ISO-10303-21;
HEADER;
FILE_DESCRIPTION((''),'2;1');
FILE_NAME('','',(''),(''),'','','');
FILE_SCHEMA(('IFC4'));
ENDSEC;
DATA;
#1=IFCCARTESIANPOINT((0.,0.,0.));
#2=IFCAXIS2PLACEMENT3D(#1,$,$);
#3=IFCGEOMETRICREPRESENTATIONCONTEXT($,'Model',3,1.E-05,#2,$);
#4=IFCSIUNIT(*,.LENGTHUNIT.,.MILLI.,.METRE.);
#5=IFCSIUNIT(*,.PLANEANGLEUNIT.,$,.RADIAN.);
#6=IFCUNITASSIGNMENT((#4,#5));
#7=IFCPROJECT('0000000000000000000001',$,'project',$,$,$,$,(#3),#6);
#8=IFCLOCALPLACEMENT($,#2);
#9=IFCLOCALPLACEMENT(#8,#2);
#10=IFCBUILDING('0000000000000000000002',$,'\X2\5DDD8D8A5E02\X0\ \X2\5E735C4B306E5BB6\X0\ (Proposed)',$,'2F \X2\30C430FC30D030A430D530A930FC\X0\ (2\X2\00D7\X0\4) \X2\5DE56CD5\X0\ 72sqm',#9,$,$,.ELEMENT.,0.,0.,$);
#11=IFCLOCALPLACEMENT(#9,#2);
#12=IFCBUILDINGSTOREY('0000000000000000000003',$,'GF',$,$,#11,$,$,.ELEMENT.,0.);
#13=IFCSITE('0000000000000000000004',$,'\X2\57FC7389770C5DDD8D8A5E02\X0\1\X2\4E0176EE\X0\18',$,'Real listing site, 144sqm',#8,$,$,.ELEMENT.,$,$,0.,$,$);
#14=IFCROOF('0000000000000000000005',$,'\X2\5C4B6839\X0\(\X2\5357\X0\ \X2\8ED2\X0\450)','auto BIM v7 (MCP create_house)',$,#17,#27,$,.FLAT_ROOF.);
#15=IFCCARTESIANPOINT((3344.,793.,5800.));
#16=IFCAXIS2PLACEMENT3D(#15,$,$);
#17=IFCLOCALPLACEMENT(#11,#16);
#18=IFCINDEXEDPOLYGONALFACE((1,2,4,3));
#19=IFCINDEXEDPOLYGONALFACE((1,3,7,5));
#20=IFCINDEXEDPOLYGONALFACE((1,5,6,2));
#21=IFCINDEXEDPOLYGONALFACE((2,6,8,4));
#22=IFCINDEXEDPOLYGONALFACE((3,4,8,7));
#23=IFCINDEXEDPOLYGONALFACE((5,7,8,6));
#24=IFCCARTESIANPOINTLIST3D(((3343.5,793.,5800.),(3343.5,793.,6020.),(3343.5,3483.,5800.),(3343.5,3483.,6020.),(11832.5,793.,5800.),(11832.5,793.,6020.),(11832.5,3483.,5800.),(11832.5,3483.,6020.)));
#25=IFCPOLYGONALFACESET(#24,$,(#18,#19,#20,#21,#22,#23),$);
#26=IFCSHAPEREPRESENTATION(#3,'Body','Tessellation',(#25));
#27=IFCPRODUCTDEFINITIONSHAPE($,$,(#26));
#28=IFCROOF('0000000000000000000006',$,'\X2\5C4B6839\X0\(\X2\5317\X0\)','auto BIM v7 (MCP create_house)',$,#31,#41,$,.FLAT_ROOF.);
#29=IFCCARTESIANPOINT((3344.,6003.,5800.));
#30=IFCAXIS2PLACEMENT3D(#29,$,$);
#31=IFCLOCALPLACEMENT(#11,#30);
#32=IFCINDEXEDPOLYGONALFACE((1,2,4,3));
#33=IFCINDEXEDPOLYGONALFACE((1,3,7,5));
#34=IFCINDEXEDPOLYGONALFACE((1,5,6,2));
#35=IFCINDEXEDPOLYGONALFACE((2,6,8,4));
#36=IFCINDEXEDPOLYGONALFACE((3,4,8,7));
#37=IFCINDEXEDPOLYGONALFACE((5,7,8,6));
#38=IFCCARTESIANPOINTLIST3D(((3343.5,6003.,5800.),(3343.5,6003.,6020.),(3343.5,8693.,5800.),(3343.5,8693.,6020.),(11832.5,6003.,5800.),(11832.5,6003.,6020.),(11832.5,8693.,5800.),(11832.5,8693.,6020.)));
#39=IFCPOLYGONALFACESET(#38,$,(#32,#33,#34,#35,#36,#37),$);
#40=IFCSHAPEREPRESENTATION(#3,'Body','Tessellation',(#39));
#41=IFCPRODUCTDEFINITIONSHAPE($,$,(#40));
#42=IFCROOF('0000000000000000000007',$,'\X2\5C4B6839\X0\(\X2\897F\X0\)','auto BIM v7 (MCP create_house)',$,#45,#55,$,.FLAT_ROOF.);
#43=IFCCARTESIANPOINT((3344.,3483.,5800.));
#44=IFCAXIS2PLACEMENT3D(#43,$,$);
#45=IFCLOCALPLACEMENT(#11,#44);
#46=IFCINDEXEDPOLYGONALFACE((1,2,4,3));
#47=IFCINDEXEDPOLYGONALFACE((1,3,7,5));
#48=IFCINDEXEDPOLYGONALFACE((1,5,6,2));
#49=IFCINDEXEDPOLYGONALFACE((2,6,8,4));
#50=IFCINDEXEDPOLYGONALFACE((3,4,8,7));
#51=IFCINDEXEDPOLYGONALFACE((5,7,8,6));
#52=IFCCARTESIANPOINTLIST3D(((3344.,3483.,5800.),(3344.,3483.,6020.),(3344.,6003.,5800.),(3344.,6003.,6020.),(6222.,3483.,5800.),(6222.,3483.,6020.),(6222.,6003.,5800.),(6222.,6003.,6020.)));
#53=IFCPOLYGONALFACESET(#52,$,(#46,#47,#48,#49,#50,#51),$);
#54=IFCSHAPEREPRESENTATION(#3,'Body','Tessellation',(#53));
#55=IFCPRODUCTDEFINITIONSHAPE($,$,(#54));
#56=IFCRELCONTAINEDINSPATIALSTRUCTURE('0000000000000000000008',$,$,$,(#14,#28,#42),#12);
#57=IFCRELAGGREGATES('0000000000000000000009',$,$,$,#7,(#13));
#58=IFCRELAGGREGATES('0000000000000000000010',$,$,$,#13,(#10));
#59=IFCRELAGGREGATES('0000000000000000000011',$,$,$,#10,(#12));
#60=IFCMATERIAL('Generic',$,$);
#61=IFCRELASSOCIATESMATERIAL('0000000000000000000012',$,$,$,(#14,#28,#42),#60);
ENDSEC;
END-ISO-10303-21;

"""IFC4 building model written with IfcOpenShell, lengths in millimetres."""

from ifc_helpers import new_model, si_unit, frame, frame_2d, origin, place, context, project, spatial, rectangle, extrude, material, element, save


model = new_model("IFC4")

# Units and contexts
model_context = context("Model", 3, precision=1e-05, world=origin())
ifc_project = project(units=[si_unit("LENGTHUNIT", "METRE", prefix="MILLI"), si_unit("PLANEANGLEUNIT", "RADIAN")], contexts=[model_context])

# Site, building, storey
site_placement = place(None, origin())
site = spatial("IfcSite", under=ifc_project, at=site_placement, Name="埼玉県川越市1丁目18", ObjectType="Real listing site, 144sqm", CompositionType="ELEMENT", RefElevation=0.0)
building_placement = place(site_placement, origin())
building = spatial("IfcBuilding", under=site, at=building_placement, Name="川越市 平屋の家 (Proposed)", ObjectType="2F ツーバイフォー (2×4) 工法 72sqm", CompositionType="ELEMENT", ElevationOfRefHeight=0.0, ElevationOfTerrain=0.0)
storey_placement = place(building_placement, origin())
storey = spatial("IfcBuildingStorey", under=building, at=storey_placement, Name="GF", CompositionType="ELEMENT", Elevation=0.0)

# Shared definitions
ifc_material = material(Name="Generic")

# Roofs
roof_1_placement = place(storey_placement, frame((3344.0, 793.0, 5800.0)))
element("IfcRoof", 1, at=roof_1_placement, inside=storey, material=ifc_material, Name="屋根(南 軒450)", Description="auto BIM v7 (MCP create_house)", PredefinedType="FLAT_ROOF", context=model_context, shape_type="SweptSolid", body=[
    extrude(rectangle(XDim=8489.0, YDim=2690.0, at=frame_2d((4244.0, 1345.0))), frame((3344.0, 793.0, 5800.0)), (0.0, 0.0, 1.0), 220.0),
])
roof_2_placement = place(storey_placement, frame((3344.0, 6003.0, 5800.0)))
element("IfcRoof", 2, at=roof_2_placement, inside=storey, material=ifc_material, Name="屋根(北)", Description="auto BIM v7 (MCP create_house)", PredefinedType="FLAT_ROOF", context=model_context, shape_type="SweptSolid", body=[
    extrude(rectangle(XDim=8489.0, YDim=2690.0, at=frame_2d((4244.0, 1345.0))), frame((3344.0, 6003.0, 5800.0)), (0.0, 0.0, 1.0), 220.0),
])
roof_3_placement = place(storey_placement, frame((3344.0, 3483.0, 5800.0)))
element("IfcRoof", 3, at=roof_3_placement, inside=storey, material=ifc_material, Name="屋根(西)", Description="auto BIM v7 (MCP create_house)", PredefinedType="FLAT_ROOF", context=model_context, shape_type="SweptSolid", body=[
    extrude(rectangle(XDim=2878.0, YDim=2520.0, at=frame_2d((1439.0, 1260.0))), frame((3344.0, 3483.0, 5800.0)), (0.0, 0.0, 1.0), 220.0),
])

save(model, "model.ifc")
